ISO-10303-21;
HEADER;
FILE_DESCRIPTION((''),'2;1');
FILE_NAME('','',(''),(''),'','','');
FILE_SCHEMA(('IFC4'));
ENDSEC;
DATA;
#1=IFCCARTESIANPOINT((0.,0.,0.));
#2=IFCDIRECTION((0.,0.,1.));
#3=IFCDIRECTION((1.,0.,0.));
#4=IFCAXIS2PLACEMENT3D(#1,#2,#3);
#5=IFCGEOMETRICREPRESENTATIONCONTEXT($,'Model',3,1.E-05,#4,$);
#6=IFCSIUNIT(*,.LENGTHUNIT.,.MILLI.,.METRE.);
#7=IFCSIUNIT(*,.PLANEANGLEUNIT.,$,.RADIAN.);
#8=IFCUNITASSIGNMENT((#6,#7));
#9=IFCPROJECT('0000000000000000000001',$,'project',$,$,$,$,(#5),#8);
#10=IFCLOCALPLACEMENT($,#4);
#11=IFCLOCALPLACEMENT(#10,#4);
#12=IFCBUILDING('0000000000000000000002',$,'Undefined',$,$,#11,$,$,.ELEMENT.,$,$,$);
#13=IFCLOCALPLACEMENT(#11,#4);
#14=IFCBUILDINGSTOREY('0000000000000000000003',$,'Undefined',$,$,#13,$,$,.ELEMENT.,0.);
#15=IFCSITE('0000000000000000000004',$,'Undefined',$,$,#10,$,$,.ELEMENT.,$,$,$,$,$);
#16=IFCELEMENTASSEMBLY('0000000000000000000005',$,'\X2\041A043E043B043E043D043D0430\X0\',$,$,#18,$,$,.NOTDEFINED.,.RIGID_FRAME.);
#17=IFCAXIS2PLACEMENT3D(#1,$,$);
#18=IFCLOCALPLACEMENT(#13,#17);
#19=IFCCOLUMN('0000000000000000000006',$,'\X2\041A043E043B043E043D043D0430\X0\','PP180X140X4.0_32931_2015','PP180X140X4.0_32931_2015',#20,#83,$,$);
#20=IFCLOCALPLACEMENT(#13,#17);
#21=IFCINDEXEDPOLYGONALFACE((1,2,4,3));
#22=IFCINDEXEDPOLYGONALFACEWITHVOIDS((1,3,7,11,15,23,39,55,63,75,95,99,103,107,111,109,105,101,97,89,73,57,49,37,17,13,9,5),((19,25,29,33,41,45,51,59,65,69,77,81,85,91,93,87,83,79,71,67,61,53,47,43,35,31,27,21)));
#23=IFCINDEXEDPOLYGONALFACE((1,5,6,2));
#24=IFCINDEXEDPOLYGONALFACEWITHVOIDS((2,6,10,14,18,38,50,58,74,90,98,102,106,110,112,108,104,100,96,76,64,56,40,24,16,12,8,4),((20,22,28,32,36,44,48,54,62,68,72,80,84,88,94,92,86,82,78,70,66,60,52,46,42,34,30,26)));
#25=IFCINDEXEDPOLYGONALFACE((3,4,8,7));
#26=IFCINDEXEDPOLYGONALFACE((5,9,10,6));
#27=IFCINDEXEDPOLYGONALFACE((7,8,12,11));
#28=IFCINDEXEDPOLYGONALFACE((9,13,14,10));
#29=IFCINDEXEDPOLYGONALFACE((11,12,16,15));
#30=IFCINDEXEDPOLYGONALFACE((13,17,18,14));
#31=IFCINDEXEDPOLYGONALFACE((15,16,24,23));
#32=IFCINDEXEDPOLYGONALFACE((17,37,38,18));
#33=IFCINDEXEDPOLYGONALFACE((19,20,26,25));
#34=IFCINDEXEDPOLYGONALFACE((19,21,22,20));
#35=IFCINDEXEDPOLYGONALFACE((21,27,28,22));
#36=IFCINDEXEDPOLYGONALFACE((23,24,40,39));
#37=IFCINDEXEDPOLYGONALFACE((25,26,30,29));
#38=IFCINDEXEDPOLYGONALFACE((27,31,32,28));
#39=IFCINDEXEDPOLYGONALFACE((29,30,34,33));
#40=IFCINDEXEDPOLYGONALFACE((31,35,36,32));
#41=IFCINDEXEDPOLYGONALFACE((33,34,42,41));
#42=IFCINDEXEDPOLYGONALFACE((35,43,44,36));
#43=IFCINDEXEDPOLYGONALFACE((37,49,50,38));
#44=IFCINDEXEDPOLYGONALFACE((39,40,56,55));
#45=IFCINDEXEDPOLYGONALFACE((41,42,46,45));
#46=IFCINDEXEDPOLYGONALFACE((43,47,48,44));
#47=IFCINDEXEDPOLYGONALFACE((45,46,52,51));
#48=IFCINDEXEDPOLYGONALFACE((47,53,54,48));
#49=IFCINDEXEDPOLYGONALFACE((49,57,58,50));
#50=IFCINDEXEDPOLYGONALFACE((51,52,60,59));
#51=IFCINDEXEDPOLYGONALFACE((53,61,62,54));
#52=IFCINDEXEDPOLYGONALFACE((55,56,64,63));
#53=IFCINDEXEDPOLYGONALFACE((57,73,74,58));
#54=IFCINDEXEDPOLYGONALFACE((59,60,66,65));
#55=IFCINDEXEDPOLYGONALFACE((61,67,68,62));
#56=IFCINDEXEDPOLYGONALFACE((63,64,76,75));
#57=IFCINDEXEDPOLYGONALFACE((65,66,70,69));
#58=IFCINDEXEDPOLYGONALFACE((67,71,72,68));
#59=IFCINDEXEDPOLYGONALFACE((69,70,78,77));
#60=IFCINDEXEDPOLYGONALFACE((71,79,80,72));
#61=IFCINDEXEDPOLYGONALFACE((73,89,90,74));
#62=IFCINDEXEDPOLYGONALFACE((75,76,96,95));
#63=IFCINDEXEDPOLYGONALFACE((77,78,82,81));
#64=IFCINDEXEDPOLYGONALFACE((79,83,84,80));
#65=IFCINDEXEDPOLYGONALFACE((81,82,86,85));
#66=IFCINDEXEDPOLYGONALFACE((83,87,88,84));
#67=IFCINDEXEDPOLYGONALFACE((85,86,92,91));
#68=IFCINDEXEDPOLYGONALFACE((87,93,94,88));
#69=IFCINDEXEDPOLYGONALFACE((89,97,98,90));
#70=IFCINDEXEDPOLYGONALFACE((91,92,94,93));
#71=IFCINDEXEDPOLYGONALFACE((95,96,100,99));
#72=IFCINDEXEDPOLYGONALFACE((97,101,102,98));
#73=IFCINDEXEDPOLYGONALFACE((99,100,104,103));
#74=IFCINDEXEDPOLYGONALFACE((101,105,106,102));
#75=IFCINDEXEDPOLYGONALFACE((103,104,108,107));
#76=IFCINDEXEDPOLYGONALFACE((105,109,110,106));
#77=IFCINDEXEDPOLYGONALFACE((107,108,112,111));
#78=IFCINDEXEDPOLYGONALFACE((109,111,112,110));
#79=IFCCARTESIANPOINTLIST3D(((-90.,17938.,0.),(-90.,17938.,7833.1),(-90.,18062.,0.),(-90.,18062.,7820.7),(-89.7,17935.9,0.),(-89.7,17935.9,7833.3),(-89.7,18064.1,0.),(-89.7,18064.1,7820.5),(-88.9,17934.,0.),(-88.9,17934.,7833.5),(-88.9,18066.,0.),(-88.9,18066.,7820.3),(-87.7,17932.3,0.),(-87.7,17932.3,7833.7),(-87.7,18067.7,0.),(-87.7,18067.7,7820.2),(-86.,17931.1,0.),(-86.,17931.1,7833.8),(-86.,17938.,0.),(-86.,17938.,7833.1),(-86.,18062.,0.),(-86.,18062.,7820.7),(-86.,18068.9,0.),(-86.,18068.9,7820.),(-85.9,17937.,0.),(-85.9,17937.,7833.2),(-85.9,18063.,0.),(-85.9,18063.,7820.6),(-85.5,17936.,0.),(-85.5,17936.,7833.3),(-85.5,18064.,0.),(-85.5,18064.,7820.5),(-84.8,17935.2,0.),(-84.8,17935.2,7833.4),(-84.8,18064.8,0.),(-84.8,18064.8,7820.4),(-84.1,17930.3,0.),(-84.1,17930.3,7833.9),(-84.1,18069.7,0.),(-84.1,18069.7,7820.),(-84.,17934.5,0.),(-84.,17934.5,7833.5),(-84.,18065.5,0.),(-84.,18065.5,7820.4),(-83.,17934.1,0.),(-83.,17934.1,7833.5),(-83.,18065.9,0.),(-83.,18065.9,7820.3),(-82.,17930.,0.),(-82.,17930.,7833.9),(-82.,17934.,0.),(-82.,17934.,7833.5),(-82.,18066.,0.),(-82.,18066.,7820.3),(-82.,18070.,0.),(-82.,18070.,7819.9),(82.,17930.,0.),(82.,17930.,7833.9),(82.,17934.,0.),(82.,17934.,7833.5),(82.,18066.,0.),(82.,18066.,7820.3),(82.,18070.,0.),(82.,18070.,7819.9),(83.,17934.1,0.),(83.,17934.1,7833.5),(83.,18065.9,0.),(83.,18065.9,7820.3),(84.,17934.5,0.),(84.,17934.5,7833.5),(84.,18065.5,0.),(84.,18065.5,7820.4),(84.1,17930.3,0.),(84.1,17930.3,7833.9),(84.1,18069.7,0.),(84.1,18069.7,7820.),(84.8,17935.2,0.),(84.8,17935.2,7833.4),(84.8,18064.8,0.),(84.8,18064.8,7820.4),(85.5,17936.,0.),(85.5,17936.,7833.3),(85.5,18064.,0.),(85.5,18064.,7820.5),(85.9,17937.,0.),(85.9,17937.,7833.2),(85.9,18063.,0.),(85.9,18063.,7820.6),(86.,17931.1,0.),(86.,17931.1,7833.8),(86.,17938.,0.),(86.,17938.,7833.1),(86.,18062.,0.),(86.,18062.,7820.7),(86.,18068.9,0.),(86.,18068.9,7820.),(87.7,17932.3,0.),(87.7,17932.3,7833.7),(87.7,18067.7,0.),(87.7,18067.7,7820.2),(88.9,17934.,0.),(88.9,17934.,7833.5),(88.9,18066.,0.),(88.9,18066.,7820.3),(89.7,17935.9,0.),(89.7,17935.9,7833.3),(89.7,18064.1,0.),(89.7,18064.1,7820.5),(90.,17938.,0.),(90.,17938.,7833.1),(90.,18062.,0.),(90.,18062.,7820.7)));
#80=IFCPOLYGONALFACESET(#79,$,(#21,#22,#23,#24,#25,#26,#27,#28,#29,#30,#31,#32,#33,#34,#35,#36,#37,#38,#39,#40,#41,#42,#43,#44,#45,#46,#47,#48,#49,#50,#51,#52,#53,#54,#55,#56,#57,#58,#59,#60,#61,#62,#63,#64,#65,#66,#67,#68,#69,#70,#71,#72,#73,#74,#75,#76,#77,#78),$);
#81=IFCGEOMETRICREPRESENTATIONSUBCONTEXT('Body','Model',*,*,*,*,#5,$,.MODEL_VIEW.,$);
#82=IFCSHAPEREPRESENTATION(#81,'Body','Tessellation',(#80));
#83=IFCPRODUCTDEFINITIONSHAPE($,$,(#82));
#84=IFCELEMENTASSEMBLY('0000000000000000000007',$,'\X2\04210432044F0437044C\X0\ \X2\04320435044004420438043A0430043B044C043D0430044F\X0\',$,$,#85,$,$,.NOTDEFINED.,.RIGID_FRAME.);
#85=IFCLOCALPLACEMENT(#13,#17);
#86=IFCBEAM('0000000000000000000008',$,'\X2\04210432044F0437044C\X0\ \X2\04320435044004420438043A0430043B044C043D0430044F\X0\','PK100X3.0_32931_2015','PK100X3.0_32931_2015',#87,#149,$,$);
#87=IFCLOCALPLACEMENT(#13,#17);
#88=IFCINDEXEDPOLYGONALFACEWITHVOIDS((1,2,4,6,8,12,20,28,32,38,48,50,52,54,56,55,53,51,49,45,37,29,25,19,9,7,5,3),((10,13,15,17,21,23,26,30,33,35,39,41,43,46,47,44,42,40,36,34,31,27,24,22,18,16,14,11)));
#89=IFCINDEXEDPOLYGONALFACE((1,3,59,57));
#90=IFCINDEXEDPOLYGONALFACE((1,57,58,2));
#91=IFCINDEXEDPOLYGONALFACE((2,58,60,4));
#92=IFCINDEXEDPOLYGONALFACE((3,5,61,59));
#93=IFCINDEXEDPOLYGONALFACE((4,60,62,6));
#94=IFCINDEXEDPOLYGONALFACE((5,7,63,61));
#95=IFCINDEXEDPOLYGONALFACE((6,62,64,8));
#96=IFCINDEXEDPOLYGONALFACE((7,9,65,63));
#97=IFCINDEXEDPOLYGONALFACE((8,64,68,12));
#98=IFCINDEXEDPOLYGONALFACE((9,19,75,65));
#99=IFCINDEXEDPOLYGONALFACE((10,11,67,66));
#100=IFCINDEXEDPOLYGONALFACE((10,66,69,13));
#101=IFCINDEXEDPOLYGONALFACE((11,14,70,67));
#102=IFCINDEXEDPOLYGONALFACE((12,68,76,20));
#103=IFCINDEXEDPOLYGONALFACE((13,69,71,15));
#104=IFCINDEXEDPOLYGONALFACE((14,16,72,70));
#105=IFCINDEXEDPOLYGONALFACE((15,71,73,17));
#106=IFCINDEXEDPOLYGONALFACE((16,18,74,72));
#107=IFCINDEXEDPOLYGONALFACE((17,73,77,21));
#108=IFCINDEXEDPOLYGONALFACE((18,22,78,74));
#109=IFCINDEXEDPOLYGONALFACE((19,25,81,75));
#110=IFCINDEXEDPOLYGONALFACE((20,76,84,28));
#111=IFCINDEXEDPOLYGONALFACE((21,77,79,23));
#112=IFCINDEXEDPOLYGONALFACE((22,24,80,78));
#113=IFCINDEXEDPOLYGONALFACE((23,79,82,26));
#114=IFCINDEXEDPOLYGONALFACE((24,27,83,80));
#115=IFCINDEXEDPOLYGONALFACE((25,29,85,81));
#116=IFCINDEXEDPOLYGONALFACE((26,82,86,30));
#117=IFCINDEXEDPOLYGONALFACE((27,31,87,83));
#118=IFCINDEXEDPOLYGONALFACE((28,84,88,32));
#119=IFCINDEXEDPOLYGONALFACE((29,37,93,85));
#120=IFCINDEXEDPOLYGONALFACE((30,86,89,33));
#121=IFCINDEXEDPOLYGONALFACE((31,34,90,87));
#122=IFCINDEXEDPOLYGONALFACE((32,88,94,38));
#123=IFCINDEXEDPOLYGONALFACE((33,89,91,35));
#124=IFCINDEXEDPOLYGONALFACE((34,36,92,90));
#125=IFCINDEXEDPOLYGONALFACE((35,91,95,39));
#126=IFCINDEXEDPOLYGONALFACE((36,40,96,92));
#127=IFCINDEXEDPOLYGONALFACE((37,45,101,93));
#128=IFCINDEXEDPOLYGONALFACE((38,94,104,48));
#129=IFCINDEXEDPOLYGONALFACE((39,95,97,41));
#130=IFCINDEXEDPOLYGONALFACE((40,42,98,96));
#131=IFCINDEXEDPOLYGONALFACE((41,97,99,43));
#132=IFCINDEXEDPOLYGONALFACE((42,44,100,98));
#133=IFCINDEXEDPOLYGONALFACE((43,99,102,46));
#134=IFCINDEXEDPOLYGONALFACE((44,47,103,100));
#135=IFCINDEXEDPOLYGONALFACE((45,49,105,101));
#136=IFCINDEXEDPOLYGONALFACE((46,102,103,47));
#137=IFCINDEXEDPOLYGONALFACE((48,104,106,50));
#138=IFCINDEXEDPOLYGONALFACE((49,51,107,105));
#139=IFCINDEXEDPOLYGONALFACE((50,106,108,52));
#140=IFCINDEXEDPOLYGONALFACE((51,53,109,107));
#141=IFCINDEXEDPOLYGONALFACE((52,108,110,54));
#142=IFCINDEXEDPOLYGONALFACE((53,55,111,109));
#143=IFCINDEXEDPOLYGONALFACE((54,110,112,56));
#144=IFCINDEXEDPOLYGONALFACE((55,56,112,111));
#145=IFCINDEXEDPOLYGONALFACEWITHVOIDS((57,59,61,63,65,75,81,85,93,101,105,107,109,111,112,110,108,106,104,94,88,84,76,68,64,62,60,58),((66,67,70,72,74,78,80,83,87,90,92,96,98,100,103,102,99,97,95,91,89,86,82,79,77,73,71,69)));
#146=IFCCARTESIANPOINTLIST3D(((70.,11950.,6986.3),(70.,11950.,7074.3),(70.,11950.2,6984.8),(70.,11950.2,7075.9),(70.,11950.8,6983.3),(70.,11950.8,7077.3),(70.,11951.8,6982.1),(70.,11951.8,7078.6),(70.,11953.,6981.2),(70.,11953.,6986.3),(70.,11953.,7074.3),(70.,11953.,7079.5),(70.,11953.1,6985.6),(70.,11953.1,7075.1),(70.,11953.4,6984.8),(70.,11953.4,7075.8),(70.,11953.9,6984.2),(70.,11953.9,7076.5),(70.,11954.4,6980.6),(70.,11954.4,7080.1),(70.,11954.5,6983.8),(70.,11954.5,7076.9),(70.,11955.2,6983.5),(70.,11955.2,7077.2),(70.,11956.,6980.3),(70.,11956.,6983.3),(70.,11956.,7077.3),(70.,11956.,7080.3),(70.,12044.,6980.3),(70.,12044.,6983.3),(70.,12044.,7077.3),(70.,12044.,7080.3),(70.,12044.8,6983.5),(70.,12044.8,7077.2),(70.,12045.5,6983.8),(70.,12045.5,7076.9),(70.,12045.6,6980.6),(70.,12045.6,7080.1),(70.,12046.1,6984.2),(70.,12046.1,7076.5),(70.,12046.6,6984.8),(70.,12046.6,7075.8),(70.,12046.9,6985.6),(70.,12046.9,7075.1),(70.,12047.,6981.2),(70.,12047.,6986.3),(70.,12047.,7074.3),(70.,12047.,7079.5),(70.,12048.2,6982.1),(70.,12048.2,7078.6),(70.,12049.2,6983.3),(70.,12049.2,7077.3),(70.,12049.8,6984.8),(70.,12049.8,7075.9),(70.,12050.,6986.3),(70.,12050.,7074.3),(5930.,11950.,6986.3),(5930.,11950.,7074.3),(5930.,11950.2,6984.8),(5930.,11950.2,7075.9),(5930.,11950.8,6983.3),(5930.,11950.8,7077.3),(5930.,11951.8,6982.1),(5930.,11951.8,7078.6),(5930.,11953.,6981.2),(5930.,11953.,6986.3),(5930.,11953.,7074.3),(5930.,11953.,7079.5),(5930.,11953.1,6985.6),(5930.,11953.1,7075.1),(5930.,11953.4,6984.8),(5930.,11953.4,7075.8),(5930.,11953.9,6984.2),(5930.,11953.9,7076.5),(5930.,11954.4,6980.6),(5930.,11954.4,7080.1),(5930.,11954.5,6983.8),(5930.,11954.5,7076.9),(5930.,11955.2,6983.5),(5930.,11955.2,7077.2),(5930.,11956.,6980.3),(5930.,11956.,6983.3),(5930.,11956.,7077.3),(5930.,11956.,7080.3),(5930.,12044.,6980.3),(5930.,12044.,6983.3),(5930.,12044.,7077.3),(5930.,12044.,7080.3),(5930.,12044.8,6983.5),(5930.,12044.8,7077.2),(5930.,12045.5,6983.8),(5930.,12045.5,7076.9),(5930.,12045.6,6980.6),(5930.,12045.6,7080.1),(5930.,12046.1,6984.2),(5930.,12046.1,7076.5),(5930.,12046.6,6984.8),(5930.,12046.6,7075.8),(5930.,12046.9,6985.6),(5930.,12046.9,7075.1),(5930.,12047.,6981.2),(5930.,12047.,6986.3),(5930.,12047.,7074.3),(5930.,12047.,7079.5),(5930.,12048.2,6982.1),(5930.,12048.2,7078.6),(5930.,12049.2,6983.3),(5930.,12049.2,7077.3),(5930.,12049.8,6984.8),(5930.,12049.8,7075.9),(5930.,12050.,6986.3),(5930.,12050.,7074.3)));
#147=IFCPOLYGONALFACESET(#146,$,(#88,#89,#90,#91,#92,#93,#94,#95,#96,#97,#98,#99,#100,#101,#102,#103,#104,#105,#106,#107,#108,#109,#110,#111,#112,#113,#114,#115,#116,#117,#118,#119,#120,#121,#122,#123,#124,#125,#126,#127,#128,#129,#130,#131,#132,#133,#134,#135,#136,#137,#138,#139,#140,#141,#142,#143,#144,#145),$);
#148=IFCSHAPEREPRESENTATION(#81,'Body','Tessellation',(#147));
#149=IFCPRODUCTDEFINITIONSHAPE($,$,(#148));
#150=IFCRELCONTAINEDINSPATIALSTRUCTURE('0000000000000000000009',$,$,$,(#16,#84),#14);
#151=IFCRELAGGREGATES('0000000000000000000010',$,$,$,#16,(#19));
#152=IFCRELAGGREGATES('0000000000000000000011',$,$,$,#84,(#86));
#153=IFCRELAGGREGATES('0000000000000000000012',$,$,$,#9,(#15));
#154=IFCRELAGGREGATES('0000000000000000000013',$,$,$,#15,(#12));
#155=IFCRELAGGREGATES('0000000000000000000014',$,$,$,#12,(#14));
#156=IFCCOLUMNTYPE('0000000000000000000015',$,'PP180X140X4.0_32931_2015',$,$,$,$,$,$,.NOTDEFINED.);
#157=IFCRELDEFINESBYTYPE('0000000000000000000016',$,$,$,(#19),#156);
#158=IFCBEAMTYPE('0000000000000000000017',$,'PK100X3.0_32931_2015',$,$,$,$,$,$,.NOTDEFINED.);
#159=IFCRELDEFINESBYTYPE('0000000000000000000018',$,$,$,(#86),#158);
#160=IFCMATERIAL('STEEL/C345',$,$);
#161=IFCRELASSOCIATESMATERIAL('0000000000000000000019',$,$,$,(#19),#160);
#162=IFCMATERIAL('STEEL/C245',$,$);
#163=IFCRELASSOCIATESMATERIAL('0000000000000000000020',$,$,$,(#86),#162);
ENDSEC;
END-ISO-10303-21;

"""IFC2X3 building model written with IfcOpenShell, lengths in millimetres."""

from ifc_helpers import new_model, si_unit, frame, origin_with_axes, origin_2d_with_axis, place, context, subcontext, project, spatial, hollow_rectangle, extrude, clip, halfspace, material, type_object, element, aggregate, save


model = new_model("IFC2X3")

# Units and contexts
model_context = context("Model", 3, precision=1e-05, world=origin_with_axes())
body_context = subcontext(model_context, "Body", "Model", "MODEL_VIEW")
ifc_project = project(units=[si_unit("LENGTHUNIT", "METRE", prefix="MILLI"), si_unit("PLANEANGLEUNIT", "RADIAN")], contexts=[model_context])

# Site, building, storey
site_placement = place(None, origin_with_axes())
site = spatial("IfcSite", under=ifc_project, at=site_placement, Name="Undefined", CompositionType="ELEMENT")
building_placement = place(site_placement, origin_with_axes())
building = spatial("IfcBuilding", under=site, at=building_placement, Name="Undefined", CompositionType="ELEMENT")
storey_placement = place(building_placement, origin_with_axes())
storey = spatial("IfcBuildingStorey", under=building, at=storey_placement, Name="Undefined", CompositionType="ELEMENT", Elevation=0.0)

# Element assembly, column
assembly_1_placement = place(storey_placement, origin_with_axes())
assembly_1 = element("IfcElementAssembly", 1, at=assembly_1_placement, inside=storey, Name="Колонна", AssemblyPlace="NOTDEFINED", PredefinedType="RIGID_FRAME")
ifc_material_1 = material(Name="STEEL/C345")
column_type = type_object("IfcColumnType", Name="PP180X140X4.0_32931_2015", PredefinedType="NOTDEFINED")
column_placement = place(assembly_1_placement, frame((0.0, 18000.0, 0.0), z_axis=(0.0, 0.0, 1.0), x_axis=(-1.0, 0.0, 0.0)))
column = element("IfcColumn", 2, at=column_placement, type_object=column_type, material=ifc_material_1, Name="Колонна", Description="PP180X140X4.0_32931_2015", ObjectType="PP180X140X4.0_32931_2015", context=body_context, shape_type="Clipping", body=[
    clip(extrude(hollow_rectangle(XDim=140.0, YDim=180.0, WallThickness=4.0, InnerFilletRadius=4.0, OuterFilletRadius=8.0, at=origin_2d_with_axis()), frame((0.0, 0.0, 7834.0), z_axis=(0.0, 0.0, -1.0), x_axis=(0.0, 1.0, 0.0)), (0.0, 0.0, 1.0), 7834.0), halfspace(frame((0.0, -165.8, 7810.3), z_axis=(0.0, 0.099504, -0.995037), x_axis=(-1.0, 0.0, 0.0)), True)),
])
aggregate(assembly_1, [column])

# Element assembly, beam
assembly_2_placement = place(storey_placement, origin_with_axes())
assembly_2 = element("IfcElementAssembly", 3, at=assembly_2_placement, inside=storey, Name="Связь вертикальная", AssemblyPlace="NOTDEFINED", PredefinedType="RIGID_FRAME")
ifc_material_2 = material(Name="STEEL/C245")
beam_type_1 = type_object("IfcBeamType", Name="PK100X3.0_32931_2015", PredefinedType="NOTDEFINED")
beam_1_placement = place(assembly_2_placement, frame((70.0, 12000.0, 7030.3), z_axis=(0.0, 0.0, 1.0), x_axis=(1.0, 0.0, 0.0)))
beam_1 = element("IfcBeam", 4, at=beam_1_placement, type_object=beam_type_1, material=ifc_material_2, Name="Связь вертикальная", Description="PK100X3.0_32931_2015", ObjectType="PK100X3.0_32931_2015", context=body_context, shape_type="SweptSolid", body=[
    extrude(hollow_rectangle(XDim=100.0, YDim=100.0, WallThickness=3.0, InnerFilletRadius=3.0, OuterFilletRadius=6.0, at=origin_2d_with_axis()), frame((5860.0, 0.0, 0.0), z_axis=(-1.0, 0.0, 0.0), x_axis=(0.0, -1.0, 0.0)), (0.0, 0.0, 1.0), 5860.0),
])
aggregate(assembly_2, [beam_1])

save(model, "model.ifc")
